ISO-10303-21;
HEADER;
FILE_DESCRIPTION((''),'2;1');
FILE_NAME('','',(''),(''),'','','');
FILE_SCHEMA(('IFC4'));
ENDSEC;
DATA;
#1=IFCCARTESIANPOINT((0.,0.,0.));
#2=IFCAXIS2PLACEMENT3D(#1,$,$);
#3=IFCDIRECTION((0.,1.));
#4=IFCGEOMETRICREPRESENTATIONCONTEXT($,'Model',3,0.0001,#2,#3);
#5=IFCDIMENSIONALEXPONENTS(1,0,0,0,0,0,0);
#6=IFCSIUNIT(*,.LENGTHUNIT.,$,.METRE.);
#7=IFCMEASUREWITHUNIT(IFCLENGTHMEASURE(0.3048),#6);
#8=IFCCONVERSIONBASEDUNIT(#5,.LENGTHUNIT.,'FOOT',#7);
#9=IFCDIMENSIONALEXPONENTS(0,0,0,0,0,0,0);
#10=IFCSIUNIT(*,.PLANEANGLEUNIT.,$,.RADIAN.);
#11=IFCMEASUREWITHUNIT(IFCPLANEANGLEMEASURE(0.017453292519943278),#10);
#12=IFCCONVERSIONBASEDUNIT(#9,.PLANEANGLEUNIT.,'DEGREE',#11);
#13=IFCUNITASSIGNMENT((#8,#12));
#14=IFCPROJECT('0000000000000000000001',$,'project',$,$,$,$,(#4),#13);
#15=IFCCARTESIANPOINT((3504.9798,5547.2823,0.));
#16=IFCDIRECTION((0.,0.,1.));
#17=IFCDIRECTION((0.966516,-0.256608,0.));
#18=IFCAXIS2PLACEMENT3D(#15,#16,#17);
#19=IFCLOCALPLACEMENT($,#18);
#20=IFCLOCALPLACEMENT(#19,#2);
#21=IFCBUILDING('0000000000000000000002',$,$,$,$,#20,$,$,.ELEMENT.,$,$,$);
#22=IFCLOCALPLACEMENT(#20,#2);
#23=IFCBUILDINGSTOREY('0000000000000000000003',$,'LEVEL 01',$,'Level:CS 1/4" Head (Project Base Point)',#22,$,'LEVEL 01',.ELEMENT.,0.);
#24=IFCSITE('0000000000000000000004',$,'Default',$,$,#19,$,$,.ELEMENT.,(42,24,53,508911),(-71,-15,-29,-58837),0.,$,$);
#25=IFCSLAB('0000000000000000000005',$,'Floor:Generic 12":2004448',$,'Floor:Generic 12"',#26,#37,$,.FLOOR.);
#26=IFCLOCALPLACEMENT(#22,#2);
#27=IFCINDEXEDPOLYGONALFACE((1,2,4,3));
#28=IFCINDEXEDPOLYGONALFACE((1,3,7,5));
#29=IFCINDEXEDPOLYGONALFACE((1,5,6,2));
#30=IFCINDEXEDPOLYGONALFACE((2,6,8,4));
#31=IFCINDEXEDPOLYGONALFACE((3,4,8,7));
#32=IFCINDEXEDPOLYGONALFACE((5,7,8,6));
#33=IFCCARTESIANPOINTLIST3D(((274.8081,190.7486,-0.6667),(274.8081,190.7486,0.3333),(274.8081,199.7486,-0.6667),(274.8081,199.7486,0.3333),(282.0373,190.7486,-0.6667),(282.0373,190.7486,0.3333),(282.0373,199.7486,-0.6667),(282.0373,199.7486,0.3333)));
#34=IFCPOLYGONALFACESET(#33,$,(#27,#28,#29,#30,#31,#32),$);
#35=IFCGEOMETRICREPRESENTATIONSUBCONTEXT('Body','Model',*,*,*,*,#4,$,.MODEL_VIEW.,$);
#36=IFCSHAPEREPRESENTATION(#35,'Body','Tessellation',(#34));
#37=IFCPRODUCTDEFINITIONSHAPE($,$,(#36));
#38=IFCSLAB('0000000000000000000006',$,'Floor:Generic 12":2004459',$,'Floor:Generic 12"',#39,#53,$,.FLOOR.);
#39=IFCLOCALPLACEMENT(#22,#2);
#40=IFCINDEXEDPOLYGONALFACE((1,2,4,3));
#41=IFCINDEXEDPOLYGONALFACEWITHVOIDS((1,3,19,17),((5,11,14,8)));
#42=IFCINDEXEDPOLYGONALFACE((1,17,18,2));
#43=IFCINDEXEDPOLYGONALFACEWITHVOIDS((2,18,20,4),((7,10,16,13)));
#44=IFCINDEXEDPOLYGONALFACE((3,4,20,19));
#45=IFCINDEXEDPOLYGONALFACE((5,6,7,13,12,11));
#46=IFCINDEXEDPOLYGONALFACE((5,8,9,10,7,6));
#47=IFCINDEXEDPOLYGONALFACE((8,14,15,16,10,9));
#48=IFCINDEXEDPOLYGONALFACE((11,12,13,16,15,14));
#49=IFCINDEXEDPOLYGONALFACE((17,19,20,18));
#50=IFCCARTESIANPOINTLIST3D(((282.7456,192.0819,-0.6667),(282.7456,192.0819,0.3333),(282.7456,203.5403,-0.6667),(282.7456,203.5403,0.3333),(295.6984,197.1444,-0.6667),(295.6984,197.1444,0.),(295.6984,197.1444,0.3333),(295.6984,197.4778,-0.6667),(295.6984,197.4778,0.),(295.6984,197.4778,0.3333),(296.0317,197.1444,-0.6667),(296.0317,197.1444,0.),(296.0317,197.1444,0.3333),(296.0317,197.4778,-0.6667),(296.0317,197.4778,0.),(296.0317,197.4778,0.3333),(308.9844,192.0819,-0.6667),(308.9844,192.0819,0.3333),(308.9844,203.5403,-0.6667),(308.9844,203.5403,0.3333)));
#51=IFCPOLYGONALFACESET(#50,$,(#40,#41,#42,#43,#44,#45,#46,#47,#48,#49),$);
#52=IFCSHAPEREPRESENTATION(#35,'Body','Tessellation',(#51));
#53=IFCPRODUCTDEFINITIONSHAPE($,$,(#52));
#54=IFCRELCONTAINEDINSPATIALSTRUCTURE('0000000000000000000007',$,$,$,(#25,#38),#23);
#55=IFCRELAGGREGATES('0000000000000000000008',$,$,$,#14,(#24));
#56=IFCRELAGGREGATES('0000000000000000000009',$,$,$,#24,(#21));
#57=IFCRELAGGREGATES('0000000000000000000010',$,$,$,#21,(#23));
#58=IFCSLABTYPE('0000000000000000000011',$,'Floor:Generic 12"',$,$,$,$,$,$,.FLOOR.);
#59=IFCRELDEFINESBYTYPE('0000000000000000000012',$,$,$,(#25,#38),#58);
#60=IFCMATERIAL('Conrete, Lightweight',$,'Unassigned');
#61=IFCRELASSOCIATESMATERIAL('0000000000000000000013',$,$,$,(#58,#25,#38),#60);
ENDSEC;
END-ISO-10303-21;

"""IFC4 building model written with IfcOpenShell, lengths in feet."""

from ifc_helpers import new_model, entity, si_unit, converted_unit, direction, frame, origin, place, context, subcontext, project, spatial, indexed_curve, outline, extrude, material, type_object, element, save


model = new_model("IFC4")

# Units and contexts
model_context = context("Model", 3, precision=0.0001, world=origin(), true_north=direction((0.0, 1.0)))
body_context = subcontext(model_context, "Body", "Model", "MODEL_VIEW")
ifc_project = project(units=[converted_unit("LENGTHUNIT", "FOOT", entity("IfcLengthMeasure", 0.3048), si_unit("LENGTHUNIT", "METRE"), dimensions=[1, 0, 0, 0, 0, 0, 0]), converted_unit("PLANEANGLEUNIT", "DEGREE", entity("IfcPlaneAngleMeasure", 0.017453292519943278), si_unit("PLANEANGLEUNIT", "RADIAN"), dimensions=[0, 0, 0, 0, 0, 0, 0])], contexts=[model_context])

# Site, building, storey
site_placement = place(None, frame((3504.9798, 5547.2823, 0.0), z_axis=(0.0, 0.0, 1.0), x_axis=(0.966516, -0.256608, 0.0)))
site = spatial("IfcSite", under=ifc_project, at=site_placement, Name="Default", CompositionType="ELEMENT", RefLatitude=(42, 24, 53, 508911), RefLongitude=(-71, -15, -29, -58837), RefElevation=0.0)
building_placement = place(site_placement, origin())
building = spatial("IfcBuilding", under=site, at=building_placement, CompositionType="ELEMENT")
storey_placement = place(building_placement, origin())
storey = spatial("IfcBuildingStorey", under=building, at=storey_placement, Name="LEVEL 01", ObjectType="Level:CS 1/4\" Head (Project Base Point)", LongName="LEVEL 01", CompositionType="ELEMENT", Elevation=0.0)

# Shared definitions
ifc_material_1 = material(Name="Conrete, Lightweight", Category="Unassigned")
slab_type = type_object("IfcSlabType", Name="Floor:Generic 12\"", PredefinedType="FLOOR", material=ifc_material_1)

# Slab
slab_1_placement = place(storey_placement, origin())
element("IfcSlab", 1, at=slab_1_placement, inside=storey, type_object=slab_type, material=ifc_material_1, Name="Floor:Generic 12\":2004448", ObjectType="Floor:Generic 12\"", PredefinedType="FLOOR", context=body_context, shape_type="SweptSolid", body=[
    extrude(outline(indexed_curve([(-4.5, -3.6146), (4.5, -3.6146), (4.5, 3.6146), (-4.5, 3.6146), (-4.5, -3.6146)], self_intersect=False)), frame((278.4227, 195.2486, 0.3333), z_axis=(0.0, 0.0, -1.0), x_axis=(0.0, 1.0, 0.0)), (0.0, 0.0, 1.0), 1.0),
])

# Slab, opening
slab_2_placement = place(storey_placement, origin())
slab_2 = element("IfcSlab", 2, at=slab_2_placement, inside=storey, type_object=slab_type, material=ifc_material_1, Name="Floor:Generic 12\":2004459", ObjectType="Floor:Generic 12\"", PredefinedType="FLOOR", context=body_context, shape_type="SweptSolid", body=[
    extrude(outline(indexed_curve([(-13.1194, -5.7292), (13.1194, -5.7292), (13.1194, 5.7292), (-13.1194, 5.7292), (-13.1194, -5.7292)], self_intersect=False), holes=[indexed_curve([(0.1667, 0.6667), (0.1667, 0.3333), (-0.1667, 0.3333), (-0.1667, 0.6667), (0.1667, 0.6667)], self_intersect=False)]), frame((295.865, 197.8111, -0.6667), z_axis=(0.0, 0.0, 1.0), x_axis=(-1.0, 0.0, 0.0)), (0.0, 0.0, 1.0), 1.0),
])
opening_1_placement = place(slab_2_placement, origin())
element("IfcOpeningElement", 3, at=opening_1_placement, cuts=slab_2, PredefinedType="OPENING", context=body_context, shape_type="SweptSolid", body=[
    extrude(outline(indexed_curve([(295.6984, 197.1444), (296.0317, 197.1444), (296.0317, 197.4778), (295.6984, 197.4778), (295.6984, 197.1444)], self_intersect=False)), origin(), (0.0, 0.0, -1.0), 11.4583),
])

save(model, "model.ifc")
